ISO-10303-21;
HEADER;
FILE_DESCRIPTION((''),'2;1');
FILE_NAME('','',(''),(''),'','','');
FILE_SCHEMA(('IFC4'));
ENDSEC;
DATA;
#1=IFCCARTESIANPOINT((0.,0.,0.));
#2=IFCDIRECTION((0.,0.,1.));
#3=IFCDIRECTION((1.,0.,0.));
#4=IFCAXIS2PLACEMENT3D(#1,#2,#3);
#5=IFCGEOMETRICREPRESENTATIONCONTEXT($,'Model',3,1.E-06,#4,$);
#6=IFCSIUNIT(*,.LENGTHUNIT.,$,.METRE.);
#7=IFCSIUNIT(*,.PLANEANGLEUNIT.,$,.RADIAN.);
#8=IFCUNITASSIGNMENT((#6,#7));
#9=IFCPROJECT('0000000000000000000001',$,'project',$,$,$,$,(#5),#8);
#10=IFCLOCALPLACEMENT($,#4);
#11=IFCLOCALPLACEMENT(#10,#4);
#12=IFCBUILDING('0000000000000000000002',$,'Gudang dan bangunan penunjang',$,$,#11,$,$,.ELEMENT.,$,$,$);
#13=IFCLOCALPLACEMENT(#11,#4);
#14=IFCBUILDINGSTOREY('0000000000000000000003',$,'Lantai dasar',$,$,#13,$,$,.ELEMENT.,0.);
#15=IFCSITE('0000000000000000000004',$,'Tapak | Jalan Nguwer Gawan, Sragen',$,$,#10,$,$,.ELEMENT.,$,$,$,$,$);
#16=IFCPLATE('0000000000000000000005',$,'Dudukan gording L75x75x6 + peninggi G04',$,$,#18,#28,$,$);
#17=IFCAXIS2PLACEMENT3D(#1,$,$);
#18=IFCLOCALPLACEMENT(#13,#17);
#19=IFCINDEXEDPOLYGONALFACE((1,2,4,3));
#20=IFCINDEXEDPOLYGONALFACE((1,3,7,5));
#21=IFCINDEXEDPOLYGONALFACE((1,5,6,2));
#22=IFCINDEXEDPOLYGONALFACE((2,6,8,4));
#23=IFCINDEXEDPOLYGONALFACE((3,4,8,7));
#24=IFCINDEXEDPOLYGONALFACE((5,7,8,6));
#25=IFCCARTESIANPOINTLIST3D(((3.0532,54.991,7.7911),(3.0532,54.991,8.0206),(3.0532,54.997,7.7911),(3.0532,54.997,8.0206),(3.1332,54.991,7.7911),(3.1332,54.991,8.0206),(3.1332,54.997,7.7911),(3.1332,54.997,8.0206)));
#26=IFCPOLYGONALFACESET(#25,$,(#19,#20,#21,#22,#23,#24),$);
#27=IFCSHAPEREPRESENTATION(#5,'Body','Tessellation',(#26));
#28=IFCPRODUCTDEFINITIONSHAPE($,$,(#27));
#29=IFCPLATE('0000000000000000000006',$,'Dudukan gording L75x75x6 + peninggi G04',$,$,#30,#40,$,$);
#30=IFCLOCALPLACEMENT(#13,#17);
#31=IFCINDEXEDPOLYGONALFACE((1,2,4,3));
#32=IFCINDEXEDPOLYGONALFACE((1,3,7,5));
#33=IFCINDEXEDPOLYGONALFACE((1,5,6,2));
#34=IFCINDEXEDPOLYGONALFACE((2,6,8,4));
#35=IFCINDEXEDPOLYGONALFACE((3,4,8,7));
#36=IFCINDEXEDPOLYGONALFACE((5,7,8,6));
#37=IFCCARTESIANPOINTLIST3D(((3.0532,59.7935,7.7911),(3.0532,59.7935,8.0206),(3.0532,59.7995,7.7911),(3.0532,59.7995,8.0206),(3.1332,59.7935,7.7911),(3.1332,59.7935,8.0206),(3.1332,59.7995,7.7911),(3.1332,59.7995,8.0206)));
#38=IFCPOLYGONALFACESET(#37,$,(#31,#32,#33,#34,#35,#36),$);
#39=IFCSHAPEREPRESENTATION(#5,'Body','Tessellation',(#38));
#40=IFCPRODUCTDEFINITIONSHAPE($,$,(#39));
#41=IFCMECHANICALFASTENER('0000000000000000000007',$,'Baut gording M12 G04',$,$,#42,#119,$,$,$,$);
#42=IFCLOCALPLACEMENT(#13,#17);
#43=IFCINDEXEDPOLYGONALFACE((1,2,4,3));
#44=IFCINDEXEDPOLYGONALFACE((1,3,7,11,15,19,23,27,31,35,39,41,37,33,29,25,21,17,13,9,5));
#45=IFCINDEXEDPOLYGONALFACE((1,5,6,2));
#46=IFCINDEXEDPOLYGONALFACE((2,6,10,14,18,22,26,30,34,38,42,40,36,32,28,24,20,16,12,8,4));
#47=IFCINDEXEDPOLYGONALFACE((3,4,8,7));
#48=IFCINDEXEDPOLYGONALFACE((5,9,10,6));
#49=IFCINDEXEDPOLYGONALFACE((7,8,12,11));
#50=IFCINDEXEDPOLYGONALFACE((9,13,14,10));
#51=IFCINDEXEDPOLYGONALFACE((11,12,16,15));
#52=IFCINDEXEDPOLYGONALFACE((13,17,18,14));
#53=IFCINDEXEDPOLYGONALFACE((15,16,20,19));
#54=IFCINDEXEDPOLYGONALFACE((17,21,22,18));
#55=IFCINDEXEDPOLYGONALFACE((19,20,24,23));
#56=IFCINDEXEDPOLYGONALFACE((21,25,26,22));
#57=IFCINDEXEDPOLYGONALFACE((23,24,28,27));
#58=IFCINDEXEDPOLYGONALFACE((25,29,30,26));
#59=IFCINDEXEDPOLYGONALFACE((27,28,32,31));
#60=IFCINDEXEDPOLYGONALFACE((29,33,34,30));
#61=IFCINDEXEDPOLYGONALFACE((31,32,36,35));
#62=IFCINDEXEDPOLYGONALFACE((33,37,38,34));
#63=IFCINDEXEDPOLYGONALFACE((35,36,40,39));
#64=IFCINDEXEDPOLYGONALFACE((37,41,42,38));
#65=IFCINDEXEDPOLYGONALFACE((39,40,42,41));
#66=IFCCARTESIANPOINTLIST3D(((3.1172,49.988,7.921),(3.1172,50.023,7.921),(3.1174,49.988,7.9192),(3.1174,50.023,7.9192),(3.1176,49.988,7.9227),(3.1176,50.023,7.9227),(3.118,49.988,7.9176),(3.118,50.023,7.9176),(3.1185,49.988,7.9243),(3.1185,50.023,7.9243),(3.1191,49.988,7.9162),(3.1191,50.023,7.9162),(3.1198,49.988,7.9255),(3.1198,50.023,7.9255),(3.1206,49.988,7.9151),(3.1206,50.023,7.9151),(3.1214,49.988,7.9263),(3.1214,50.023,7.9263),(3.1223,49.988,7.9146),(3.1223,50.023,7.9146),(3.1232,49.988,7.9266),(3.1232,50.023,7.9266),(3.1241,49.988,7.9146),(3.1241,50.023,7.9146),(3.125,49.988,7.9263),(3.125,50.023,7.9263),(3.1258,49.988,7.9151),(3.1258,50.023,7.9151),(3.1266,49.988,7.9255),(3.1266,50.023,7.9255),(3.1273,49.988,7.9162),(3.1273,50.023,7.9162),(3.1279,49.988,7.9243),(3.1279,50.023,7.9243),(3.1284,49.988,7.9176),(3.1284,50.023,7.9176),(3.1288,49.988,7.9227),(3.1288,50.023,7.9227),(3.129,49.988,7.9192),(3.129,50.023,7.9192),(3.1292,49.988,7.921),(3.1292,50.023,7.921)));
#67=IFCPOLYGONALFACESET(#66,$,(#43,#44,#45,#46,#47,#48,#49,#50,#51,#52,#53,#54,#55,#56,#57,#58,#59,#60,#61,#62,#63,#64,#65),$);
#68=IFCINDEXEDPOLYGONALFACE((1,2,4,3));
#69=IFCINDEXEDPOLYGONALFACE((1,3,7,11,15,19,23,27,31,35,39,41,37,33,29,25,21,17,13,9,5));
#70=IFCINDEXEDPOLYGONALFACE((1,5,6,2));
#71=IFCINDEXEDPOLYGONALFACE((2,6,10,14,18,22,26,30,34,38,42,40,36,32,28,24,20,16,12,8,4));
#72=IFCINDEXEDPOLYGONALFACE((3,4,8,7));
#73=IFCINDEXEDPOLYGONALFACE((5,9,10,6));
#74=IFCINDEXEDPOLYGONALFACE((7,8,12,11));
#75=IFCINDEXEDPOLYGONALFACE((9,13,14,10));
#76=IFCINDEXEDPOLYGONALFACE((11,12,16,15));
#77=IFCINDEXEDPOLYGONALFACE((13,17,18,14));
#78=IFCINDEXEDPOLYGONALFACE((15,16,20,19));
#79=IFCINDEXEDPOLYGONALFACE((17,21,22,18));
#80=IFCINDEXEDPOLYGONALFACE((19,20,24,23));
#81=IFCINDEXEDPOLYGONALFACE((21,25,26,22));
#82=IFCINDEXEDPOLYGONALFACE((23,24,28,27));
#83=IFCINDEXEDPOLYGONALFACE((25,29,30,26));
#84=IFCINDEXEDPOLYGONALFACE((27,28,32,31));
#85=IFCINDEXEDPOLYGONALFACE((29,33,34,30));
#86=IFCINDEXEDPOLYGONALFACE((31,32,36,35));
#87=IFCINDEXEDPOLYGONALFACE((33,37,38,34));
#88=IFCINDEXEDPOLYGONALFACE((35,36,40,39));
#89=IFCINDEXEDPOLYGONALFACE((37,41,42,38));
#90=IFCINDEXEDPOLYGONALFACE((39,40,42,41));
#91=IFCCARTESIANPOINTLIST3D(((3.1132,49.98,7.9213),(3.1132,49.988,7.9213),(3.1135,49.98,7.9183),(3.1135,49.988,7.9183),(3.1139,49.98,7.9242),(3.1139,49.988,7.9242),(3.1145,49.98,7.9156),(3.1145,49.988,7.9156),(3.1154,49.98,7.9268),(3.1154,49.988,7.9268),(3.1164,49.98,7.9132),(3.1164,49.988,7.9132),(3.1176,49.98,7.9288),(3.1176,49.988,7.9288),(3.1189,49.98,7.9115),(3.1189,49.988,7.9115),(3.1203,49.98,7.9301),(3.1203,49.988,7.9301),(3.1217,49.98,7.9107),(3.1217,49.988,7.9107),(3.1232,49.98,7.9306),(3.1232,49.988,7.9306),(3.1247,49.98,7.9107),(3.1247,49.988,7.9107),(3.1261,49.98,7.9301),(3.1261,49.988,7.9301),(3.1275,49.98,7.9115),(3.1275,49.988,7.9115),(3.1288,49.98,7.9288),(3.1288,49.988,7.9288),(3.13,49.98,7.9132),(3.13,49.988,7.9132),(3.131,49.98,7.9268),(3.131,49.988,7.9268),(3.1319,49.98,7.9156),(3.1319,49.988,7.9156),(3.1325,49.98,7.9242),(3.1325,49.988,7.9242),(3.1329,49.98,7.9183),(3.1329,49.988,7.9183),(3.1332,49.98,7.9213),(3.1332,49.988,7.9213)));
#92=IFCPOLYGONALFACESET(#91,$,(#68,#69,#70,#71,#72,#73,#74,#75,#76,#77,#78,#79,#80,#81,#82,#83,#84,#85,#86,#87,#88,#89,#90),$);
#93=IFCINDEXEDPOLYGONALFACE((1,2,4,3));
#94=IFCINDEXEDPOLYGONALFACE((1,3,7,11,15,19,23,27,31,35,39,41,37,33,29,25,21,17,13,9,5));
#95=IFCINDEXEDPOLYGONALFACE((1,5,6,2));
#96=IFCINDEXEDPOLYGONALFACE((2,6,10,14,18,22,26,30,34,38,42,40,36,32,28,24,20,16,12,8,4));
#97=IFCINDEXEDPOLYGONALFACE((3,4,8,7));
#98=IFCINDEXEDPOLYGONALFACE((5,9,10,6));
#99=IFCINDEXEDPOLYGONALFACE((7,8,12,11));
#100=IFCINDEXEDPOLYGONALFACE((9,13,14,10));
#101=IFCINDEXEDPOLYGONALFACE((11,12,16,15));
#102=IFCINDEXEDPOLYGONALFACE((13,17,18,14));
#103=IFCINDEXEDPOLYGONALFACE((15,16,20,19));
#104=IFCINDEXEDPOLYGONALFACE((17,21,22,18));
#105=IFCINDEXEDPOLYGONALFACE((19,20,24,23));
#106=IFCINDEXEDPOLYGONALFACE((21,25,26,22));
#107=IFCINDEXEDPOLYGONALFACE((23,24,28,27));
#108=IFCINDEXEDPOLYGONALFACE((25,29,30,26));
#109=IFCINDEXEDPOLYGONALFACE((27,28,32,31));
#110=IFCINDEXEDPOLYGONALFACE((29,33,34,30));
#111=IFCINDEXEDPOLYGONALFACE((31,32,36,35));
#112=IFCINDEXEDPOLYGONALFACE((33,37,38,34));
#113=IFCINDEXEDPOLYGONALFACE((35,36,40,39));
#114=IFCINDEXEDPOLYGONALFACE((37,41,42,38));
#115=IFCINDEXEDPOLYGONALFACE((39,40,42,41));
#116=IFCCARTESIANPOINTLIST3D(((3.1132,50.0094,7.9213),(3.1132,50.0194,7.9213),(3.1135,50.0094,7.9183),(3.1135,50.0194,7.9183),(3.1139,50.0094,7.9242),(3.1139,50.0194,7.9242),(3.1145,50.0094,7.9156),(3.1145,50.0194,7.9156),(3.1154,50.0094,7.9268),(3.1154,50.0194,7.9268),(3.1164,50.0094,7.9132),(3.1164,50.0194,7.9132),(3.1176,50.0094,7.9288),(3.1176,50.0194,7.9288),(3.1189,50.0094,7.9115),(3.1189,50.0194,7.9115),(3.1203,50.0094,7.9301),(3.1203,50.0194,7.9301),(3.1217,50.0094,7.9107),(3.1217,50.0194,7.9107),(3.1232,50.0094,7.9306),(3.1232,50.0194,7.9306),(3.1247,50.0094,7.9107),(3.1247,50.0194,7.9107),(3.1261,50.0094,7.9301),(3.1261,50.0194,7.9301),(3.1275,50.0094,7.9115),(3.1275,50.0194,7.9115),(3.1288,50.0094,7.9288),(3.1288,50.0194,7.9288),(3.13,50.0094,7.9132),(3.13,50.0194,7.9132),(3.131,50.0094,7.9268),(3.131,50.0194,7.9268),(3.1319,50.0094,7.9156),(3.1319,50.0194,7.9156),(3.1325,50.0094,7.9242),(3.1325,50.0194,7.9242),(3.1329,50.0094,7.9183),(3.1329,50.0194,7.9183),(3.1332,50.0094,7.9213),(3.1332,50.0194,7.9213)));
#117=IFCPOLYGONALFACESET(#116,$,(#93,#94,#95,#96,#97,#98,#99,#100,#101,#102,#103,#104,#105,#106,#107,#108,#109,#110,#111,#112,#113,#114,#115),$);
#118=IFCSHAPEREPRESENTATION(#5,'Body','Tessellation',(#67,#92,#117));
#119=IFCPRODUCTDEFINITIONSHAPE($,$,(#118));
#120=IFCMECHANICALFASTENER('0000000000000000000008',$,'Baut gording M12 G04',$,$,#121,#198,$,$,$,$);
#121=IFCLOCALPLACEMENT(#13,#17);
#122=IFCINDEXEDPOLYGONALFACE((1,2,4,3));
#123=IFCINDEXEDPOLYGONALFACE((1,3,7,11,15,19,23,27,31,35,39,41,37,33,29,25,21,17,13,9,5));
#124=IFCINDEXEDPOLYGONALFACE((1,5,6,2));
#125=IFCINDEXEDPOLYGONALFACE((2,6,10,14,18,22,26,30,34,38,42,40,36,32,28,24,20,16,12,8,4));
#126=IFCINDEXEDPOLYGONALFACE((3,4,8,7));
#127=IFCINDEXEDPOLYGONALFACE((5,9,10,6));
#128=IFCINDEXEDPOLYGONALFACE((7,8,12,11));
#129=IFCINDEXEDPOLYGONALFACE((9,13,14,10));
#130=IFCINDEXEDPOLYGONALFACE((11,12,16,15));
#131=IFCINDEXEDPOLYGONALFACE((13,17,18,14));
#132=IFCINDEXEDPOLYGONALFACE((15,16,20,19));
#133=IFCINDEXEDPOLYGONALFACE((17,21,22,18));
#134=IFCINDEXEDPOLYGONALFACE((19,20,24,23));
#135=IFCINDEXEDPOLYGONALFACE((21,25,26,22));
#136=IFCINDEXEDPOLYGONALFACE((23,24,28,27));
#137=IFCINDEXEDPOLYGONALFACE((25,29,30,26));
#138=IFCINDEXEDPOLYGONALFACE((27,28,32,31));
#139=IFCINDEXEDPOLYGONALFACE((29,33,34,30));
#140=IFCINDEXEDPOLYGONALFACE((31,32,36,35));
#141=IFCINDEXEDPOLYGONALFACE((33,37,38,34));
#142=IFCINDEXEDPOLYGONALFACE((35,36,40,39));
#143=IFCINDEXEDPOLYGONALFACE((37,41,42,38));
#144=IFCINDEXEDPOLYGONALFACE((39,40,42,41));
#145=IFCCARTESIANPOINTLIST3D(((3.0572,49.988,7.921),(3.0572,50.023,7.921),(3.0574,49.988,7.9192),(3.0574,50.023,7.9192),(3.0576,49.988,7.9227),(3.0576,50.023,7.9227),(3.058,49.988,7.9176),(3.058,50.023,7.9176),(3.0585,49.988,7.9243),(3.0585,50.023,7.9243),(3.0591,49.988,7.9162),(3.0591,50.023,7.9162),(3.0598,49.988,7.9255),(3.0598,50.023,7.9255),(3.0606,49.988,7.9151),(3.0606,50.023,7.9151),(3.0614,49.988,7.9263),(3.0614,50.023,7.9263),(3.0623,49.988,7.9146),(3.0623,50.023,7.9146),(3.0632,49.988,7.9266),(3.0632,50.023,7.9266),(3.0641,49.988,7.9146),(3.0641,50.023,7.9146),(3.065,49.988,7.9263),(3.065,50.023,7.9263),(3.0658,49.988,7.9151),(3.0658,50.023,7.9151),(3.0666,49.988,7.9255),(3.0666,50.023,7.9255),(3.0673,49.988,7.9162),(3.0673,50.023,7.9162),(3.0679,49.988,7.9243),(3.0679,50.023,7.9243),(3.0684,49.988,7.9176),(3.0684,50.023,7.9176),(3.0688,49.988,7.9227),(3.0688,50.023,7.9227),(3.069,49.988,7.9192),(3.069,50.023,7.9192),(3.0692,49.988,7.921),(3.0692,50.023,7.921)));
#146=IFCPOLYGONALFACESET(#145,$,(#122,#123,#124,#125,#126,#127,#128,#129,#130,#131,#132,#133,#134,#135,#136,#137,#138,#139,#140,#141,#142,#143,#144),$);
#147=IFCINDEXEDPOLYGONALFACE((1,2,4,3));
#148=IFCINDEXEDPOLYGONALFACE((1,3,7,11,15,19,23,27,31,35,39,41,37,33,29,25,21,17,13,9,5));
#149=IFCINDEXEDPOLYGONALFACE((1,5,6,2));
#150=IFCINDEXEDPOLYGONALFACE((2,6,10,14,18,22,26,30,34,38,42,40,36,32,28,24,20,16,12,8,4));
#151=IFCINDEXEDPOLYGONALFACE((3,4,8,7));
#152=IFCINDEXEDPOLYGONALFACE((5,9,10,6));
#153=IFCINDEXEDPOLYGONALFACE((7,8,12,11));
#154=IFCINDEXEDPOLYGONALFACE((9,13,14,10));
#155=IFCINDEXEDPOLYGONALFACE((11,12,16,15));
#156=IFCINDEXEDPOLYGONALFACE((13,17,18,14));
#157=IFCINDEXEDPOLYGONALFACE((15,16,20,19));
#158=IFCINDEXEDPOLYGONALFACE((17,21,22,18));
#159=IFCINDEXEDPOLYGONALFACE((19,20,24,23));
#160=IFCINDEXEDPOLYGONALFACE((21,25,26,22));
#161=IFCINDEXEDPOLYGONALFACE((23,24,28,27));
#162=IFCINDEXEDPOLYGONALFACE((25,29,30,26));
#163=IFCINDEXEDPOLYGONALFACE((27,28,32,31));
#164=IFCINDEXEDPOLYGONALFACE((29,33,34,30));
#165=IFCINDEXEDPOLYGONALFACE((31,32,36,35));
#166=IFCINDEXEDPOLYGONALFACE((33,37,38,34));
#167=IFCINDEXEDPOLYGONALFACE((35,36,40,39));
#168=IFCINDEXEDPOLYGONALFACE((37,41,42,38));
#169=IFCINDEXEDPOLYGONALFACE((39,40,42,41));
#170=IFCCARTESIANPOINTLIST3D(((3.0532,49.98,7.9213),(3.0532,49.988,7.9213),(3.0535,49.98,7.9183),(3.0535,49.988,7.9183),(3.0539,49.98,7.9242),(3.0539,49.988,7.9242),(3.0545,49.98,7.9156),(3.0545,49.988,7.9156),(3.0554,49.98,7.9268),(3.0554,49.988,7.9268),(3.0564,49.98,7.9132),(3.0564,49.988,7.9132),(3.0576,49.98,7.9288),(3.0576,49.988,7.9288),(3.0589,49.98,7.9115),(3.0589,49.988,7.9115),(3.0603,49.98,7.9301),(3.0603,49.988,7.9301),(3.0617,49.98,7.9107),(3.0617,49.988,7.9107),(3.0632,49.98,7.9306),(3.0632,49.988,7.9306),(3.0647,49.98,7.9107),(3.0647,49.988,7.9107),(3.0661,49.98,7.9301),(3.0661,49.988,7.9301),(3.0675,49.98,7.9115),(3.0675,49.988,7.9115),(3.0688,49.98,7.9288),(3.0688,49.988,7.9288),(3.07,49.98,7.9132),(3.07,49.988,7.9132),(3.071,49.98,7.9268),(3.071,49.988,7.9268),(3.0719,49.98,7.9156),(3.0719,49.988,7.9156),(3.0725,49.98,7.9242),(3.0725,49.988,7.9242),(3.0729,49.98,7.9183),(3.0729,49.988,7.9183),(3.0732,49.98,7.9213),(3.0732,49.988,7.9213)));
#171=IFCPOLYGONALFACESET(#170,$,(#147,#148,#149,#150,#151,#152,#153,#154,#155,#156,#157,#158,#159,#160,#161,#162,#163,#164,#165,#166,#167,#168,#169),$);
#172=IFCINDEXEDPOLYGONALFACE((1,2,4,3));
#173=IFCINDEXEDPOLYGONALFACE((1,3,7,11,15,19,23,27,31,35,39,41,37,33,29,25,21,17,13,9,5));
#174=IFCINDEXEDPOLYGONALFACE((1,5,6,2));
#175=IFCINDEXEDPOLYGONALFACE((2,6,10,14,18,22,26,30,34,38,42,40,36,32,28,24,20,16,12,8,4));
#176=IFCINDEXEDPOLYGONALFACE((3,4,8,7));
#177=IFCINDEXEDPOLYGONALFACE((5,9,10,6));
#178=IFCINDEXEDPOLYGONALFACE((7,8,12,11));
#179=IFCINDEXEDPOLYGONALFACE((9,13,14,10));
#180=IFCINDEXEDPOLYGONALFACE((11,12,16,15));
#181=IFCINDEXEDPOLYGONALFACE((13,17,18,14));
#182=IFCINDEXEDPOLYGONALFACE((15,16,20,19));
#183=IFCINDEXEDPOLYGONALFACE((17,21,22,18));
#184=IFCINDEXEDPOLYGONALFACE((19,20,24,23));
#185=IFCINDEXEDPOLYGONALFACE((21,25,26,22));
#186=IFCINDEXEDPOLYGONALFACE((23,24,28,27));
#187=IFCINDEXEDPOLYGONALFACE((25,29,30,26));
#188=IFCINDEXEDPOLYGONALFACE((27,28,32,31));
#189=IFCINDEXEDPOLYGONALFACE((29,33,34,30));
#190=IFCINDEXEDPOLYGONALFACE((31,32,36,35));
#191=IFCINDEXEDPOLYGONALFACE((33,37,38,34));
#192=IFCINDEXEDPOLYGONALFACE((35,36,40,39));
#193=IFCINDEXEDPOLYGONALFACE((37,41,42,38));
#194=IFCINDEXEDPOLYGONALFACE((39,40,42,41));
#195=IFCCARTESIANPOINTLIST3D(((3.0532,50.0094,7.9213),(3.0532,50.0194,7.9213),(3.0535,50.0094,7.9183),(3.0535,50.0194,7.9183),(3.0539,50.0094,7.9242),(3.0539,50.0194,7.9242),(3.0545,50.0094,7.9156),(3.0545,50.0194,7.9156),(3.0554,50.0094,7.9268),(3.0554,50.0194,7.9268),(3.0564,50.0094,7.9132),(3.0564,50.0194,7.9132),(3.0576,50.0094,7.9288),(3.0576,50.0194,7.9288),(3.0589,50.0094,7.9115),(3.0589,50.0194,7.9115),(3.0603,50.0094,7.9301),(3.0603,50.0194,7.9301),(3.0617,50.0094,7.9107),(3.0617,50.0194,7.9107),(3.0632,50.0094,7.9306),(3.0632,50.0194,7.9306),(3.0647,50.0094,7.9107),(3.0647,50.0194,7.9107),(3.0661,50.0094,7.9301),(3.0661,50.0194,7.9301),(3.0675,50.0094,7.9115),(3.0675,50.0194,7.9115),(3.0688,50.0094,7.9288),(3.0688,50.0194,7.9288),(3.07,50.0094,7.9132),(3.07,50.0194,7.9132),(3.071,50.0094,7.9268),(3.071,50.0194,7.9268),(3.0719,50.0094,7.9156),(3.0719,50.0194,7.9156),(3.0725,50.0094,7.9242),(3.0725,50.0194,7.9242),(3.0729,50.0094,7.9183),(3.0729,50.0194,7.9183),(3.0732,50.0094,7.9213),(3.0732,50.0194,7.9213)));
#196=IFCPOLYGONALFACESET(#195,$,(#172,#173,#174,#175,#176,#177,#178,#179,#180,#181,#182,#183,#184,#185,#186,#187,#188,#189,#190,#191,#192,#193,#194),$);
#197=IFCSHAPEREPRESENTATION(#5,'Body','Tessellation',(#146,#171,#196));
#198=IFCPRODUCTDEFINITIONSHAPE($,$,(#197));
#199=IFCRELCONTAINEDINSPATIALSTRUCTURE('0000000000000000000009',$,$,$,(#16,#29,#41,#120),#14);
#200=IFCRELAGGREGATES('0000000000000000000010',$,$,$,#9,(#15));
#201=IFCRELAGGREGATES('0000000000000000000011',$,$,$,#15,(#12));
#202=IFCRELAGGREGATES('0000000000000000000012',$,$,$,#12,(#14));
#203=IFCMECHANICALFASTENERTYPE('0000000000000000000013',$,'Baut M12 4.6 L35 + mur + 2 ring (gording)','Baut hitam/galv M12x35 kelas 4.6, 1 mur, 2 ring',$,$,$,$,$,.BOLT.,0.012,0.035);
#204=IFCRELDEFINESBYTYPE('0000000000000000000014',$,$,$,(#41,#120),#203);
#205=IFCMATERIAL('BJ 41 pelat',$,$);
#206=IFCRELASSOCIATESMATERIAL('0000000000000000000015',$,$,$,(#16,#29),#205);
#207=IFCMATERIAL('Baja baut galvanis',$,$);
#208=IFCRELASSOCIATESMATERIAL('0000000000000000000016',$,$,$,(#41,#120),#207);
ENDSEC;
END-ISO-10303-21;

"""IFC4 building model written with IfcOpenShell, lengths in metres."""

from ifc_helpers import new_model, si_unit, frame, origin_with_axes, place, context, project, spatial, rectangle, circle, extrude, source, transform, mapped, material, type_object, type_shapes, element, save


model = new_model("IFC4")

# Units and contexts
model_context = context("Model", 3, precision=1e-06, world=origin_with_axes())
ifc_project = project(units=[si_unit("LENGTHUNIT", "METRE"), si_unit("PLANEANGLEUNIT", "RADIAN")], contexts=[model_context])

# Site, building, storey
site_placement = place(None, origin_with_axes())
site = spatial("IfcSite", under=ifc_project, at=site_placement, Name="Tapak | Jalan Nguwer Gawan, Sragen", CompositionType="ELEMENT")
building_placement = place(site_placement, origin_with_axes())
building = spatial("IfcBuilding", under=site, at=building_placement, Name="Gudang dan bangunan penunjang", CompositionType="ELEMENT")
storey_placement = place(building_placement, origin_with_axes())
storey = spatial("IfcBuildingStorey", under=building, at=storey_placement, Name="Lantai dasar", CompositionType="ELEMENT", Elevation=0.0)

# Shared definitions
placement = place(None, origin_with_axes())

# Plates
ifc_material_1 = material(Name="BJ 41 pelat")
element("IfcPlate", 1, at=placement, inside=storey, material=ifc_material_1, Name="Dudukan gording L75x75x6 + peninggi G04", context=model_context, shape_type="SweptSolid", body=[
    extrude(rectangle(XDim=0.08, YDim=0.006), frame((3.0932, 54.994, 7.7911), z_axis=(0.0, 0.0, 1.0), x_axis=(1.0, 0.0, 0.0)), (0.0, 0.0, 1.0), 0.2294),
])
element("IfcPlate", 2, at=placement, inside=storey, material=ifc_material_1, Name="Dudukan gording L75x75x6 + peninggi G04", context=model_context, shape_type="SweptSolid", body=[
    extrude(rectangle(XDim=0.08, YDim=0.006), frame((3.0932, 59.7965, 7.7911), z_axis=(0.0, 0.0, 1.0), x_axis=(1.0, 0.0, 0.0)), (0.0, 0.0, 1.0), 0.2294),
])

# Mechanical fasteners
ifc_material_2 = material(Name="Baja baut galvanis")
mechanical_fastener_type = type_object("IfcMechanicalFastenerType", Name="Baut M12 4.6 L35 + mur + 2 ring (gording)", Description="Baut hitam/galv M12x35 kelas 4.6, 1 mur, 2 ring", NominalDiameter=0.012, NominalLength=0.035, PredefinedType="BOLT")
shared_shape = source(origin_with_axes(), model_context, "Body", "SweptSolid", [
    extrude(circle(Radius=0.006), origin_with_axes(), (0.0, 0.0, 1.0), 0.035),
    extrude(circle(Radius=0.01), frame((0.0, 0.0, -0.008), z_axis=(0.0, 0.0, 1.0), x_axis=(1.0, 0.0, 0.0)), (0.0, 0.0, 1.0), 0.008),
    extrude(circle(Radius=0.01), frame((0.0, 0.0, 0.0214), z_axis=(0.0, 0.0, 1.0), x_axis=(1.0, 0.0, 0.0)), (0.0, 0.0, 1.0), 0.01),
])
type_shapes(mechanical_fastener_type, [shared_shape])
element("IfcMechanicalFastener", 3, at=placement, inside=storey, type_object=mechanical_fastener_type, material=ifc_material_2, Name="Baut gording M12 G04", context=model_context, shape_type="MappedRepresentation", body=[
    mapped(shared_shape, transform((3.1232, 49.988, 7.9206), x_axis=(0.0, 0.0, 1.0), y_axis=(1.0, 0.0, 0.0), z_axis=(0.0, 1.0, 0.0), scale=1.0)),
])
element("IfcMechanicalFastener", 4, at=placement, inside=storey, type_object=mechanical_fastener_type, material=ifc_material_2, Name="Baut gording M12 G04", context=model_context, shape_type="MappedRepresentation", body=[
    mapped(shared_shape, transform((3.0632, 49.988, 7.9206), x_axis=(0.0, 0.0, 1.0), y_axis=(1.0, 0.0, 0.0), z_axis=(0.0, 1.0, 0.0), scale=1.0)),
])

save(model, "model.ifc")
